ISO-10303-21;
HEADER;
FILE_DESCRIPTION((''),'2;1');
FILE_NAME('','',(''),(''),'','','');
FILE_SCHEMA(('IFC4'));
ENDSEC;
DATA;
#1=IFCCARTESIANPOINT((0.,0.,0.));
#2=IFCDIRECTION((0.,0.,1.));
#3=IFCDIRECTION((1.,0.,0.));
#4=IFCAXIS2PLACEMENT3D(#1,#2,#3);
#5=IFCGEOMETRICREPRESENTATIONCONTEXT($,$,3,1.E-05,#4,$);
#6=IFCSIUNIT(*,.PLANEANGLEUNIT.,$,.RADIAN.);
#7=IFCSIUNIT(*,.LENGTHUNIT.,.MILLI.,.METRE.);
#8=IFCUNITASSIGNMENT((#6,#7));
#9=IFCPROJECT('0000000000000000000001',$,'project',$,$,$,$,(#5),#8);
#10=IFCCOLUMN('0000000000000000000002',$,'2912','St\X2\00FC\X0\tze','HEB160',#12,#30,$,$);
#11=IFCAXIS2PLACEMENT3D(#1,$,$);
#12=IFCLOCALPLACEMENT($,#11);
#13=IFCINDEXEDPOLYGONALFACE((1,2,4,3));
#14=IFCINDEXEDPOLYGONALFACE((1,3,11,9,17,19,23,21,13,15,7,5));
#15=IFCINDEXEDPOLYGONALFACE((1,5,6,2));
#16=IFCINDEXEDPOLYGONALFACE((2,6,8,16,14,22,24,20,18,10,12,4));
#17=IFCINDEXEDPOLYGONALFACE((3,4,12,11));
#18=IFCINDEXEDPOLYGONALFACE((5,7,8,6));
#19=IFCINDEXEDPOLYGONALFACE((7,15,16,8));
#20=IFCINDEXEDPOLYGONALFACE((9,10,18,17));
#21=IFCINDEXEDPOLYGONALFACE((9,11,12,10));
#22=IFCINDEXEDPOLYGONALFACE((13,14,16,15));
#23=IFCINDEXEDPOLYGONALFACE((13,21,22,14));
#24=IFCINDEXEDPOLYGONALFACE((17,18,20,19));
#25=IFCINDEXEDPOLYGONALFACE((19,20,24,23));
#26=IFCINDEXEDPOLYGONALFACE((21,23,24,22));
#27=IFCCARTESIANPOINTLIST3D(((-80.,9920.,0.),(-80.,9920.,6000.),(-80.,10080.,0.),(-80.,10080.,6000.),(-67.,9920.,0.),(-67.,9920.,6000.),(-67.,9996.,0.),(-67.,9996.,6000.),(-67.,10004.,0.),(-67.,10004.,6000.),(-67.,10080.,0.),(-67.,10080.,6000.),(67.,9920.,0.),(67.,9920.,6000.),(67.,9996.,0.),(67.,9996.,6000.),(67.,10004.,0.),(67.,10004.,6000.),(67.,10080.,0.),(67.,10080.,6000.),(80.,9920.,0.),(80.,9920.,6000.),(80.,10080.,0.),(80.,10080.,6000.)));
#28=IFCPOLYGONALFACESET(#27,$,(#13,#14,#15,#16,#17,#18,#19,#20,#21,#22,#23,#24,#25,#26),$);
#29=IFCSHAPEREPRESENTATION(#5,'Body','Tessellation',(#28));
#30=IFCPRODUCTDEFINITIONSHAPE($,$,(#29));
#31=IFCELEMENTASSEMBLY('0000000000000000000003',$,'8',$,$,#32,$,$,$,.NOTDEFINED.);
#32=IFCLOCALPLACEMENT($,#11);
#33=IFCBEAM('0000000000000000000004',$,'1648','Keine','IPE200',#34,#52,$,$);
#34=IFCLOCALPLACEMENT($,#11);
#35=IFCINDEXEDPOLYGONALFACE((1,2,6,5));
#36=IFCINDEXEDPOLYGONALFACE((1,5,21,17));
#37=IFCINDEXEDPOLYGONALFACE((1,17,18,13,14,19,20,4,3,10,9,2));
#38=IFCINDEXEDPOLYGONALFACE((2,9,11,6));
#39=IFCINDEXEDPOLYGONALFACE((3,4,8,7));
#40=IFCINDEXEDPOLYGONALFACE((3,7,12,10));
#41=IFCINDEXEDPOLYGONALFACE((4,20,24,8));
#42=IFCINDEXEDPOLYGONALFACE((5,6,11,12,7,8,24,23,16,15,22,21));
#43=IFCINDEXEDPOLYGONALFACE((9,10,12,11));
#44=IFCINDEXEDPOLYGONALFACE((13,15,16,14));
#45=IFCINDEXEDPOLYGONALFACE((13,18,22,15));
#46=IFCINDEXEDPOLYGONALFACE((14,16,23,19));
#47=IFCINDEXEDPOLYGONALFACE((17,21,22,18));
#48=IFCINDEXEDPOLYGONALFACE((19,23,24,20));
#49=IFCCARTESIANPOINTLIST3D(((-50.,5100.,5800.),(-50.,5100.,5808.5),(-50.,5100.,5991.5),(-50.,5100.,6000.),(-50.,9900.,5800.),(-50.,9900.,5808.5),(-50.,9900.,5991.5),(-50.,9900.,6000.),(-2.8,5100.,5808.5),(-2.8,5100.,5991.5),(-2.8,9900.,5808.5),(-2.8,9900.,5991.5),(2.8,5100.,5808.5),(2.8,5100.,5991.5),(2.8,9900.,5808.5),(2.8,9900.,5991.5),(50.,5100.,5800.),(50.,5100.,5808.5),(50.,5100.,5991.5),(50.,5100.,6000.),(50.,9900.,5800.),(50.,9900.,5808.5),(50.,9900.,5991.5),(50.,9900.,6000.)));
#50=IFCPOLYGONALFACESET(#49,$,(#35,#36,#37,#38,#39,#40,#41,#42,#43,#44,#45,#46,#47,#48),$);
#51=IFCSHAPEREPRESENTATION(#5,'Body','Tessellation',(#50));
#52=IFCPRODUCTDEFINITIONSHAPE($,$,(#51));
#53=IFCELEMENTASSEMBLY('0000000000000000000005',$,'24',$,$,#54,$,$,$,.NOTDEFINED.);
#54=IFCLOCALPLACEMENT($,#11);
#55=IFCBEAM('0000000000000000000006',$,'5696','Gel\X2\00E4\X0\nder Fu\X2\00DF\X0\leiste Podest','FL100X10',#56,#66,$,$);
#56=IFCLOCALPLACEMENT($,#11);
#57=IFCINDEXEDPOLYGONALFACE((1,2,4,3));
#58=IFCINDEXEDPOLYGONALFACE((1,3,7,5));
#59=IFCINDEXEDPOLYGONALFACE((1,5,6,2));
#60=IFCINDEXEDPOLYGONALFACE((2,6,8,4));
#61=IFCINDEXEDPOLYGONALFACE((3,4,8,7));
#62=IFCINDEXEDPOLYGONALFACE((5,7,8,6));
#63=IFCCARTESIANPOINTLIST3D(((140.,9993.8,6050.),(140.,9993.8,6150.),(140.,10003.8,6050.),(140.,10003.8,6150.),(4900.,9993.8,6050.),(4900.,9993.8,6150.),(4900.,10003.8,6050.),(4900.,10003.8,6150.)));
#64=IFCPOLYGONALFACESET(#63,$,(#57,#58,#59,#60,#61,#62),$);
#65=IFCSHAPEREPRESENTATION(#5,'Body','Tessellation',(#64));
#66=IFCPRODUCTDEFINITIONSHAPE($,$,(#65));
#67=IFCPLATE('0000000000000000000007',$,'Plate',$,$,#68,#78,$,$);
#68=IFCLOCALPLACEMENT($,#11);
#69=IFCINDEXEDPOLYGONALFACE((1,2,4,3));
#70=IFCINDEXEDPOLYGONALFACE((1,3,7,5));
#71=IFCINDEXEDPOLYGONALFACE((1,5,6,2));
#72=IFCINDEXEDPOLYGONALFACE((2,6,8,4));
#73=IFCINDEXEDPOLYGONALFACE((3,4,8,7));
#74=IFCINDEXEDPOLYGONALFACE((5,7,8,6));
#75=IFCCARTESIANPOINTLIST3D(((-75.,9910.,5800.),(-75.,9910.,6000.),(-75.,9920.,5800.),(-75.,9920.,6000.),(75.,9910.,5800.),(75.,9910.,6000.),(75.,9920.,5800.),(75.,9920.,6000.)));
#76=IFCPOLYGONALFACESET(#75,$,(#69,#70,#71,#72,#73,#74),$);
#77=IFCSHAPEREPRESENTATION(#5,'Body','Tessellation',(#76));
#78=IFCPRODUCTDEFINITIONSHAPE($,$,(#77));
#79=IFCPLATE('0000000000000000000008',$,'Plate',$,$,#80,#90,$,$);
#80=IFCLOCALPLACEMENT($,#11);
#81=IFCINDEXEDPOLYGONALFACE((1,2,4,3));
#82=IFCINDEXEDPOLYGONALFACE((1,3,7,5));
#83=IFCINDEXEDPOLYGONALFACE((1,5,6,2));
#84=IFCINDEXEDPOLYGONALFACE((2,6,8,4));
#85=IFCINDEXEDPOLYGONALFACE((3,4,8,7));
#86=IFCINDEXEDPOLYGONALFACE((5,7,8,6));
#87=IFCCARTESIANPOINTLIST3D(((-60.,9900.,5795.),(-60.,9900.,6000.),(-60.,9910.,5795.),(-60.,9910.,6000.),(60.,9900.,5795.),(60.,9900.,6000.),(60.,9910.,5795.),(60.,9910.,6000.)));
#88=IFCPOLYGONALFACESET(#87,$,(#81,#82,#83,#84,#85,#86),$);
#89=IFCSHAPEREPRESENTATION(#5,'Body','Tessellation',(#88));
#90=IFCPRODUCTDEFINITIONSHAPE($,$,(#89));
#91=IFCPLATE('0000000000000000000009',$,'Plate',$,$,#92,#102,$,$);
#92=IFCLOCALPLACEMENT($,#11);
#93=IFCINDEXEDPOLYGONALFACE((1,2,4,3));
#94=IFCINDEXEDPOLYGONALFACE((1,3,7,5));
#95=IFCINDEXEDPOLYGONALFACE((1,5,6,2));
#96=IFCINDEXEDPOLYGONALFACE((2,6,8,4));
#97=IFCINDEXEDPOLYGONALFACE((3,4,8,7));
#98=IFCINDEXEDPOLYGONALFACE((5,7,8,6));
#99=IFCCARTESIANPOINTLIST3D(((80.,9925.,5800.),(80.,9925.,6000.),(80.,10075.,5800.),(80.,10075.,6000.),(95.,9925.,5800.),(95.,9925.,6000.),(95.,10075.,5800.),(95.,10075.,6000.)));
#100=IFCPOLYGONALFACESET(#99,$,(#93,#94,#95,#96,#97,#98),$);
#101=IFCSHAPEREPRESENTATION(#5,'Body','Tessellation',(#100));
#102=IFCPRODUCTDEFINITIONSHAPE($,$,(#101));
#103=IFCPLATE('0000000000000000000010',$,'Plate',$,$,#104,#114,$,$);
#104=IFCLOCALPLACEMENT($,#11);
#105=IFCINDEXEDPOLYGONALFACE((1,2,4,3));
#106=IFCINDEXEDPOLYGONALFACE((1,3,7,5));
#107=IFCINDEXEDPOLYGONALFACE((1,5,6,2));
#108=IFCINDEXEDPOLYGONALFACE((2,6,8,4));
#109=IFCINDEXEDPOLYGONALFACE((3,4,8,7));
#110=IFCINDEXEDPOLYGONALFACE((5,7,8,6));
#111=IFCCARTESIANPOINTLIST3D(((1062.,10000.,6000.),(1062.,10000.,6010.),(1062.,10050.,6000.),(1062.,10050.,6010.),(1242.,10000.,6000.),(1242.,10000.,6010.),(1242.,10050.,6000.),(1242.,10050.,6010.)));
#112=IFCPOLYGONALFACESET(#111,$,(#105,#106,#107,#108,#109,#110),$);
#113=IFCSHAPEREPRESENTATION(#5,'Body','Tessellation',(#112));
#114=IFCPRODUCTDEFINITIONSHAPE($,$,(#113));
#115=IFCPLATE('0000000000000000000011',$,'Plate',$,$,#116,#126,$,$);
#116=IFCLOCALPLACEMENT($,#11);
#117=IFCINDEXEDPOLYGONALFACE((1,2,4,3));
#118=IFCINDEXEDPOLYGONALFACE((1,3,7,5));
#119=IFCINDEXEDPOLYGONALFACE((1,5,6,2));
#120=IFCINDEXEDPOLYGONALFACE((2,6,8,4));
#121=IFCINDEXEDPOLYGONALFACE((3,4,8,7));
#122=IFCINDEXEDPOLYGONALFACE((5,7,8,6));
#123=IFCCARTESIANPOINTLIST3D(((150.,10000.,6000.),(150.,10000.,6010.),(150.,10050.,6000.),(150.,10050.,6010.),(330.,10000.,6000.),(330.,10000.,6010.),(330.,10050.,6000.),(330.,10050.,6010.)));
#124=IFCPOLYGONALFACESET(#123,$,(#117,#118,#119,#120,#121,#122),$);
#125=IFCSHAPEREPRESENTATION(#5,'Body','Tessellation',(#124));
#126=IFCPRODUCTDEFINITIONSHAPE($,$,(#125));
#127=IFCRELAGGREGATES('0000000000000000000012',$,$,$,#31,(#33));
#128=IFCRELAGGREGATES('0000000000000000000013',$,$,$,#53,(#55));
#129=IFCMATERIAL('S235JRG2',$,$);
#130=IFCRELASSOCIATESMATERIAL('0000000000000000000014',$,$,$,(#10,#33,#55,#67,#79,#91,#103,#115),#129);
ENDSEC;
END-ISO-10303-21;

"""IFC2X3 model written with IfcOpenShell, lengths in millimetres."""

from ifc_helpers import new_model, si_unit, frame, origin_with_axes, place, context, project, polyline, outline, extrude, clip, halfspace, material, element, aggregate, save


model = new_model("IFC2X3")

# Units and contexts
context_of_model = context(None, 3, precision=1e-05, world=origin_with_axes())
ifc_project = project(units=[si_unit("PLANEANGLEUNIT", "RADIAN"), si_unit("LENGTHUNIT", "METRE", prefix="MILLI")], contexts=[context_of_model])

# Column
ifc_material = material(Name="S235JRG2")
placement_1 = place(None, frame((0.0, 10000.0, 6000.0), z_axis=(-1.0, 0.0, 0.0), x_axis=(0.0, 0.0, -1.0)))
column_placement = place(placement_1, origin_with_axes())
element("IfcColumn", 1, at=column_placement, material=ifc_material, Name="2912", Description="Stütze", ObjectType="HEB160", context=context_of_model, shape_type="Clipping", body=[
    clip(extrude(outline(polyline([(80.0, -80.0), (80.0, -67.0), (4.0, -67.0), (4.0, 67.0), (80.0, 67.0), (80.0, 80.0), (-80.0, 80.0), (-80.0, 67.0), (-4.0, 67.0), (-4.0, -67.0), (-80.0, -67.0), (-80.0, -80.0), (80.0, -80.0), (80.0, -80.0)])), frame((0.0, 0.0, 0.0), z_axis=(1.0, 0.0, 0.0), x_axis=(0.0, 1.0, 0.0)), (0.0, 0.0, 1.0), 6000.0), halfspace(frame((6000.0, 0.0, 0.0), z_axis=(1.0, 0.0, 0.0), x_axis=(0.0, 0.0, 1.0)), False)),
])

# Element assembly, beam
assembly_1_placement = place(None, frame((0.0, 10000.0, 6000.0), z_axis=(0.0, 0.0, 1.0), x_axis=(0.0, -1.0, 0.0)))
assembly_1 = element("IfcElementAssembly", 2, at=assembly_1_placement, Name="8", PredefinedType="NOTDEFINED")
placement_2 = place(None, frame((0.0, 10000.0, 5900.0), z_axis=(0.0, 0.0, 1.0), x_axis=(0.0, -1.0, 0.0)))
beam_1_placement = place(placement_2, origin_with_axes())
beam_1 = element("IfcBeam", 3, at=beam_1_placement, material=ifc_material, Name="1648", Description="Keine", ObjectType="IPE200", context=context_of_model, shape_type="Clipping", body=[
    clip(clip(extrude(outline(polyline([(50.0, -100.0), (50.0, -91.5), (2.8, -91.5), (2.8, 91.5), (50.0, 91.5), (50.0, 100.0), (-50.0, 100.0), (-50.0, 91.5), (-2.8, 91.5), (-2.8, -91.5), (-50.0, -91.5), (-50.0, -100.0), (50.0, -100.0), (50.0, -100.0)])), frame((0.0, 0.0, 0.0), z_axis=(1.0, 0.0, 0.0), x_axis=(0.0, 1.0, 0.0)), (0.0, 0.0, 1.0), 5000.0), halfspace(frame((4900.0, 0.0, 100.0), z_axis=(1.0, 0.0, 0.0), x_axis=(0.0, 0.0, 1.0)), False)), halfspace(frame((100.0, 0.0, 100.0), z_axis=(-1.0, 0.0, 0.0), x_axis=(0.0, 0.0, -1.0)), False)),
])
aggregate(assembly_1, [beam_1])

# Element assembly, beam
assembly_2_placement = place(None, frame((140.0, 9998.8, 6100.0), z_axis=(0.0, 0.0, 1.0), x_axis=(1.0, 0.0, 0.0)))
assembly_2 = element("IfcElementAssembly", 4, at=assembly_2_placement, Name="24", PredefinedType="NOTDEFINED")
placement_3 = place(None, frame((140.0, 9998.8, 6100.0), z_axis=(0.0, 0.0, 1.0), x_axis=(1.0, 0.0, 0.0)))
beam_2_placement = place(placement_3, origin_with_axes())
beam_2 = element("IfcBeam", 5, at=beam_2_placement, material=ifc_material, Name="5696", Description="Geländer Fußleiste Podest", ObjectType="FL100X10", context=context_of_model, shape_type="SweptSolid", body=[
    extrude(outline(polyline([(5.0, -50.0), (5.0, 50.0), (-5.0, 50.0), (-5.0, -50.0), (5.0, -50.0), (5.0, -50.0)])), frame((0.0, 0.0, 0.0), z_axis=(1.0, 0.0, 0.0), x_axis=(0.0, 1.0, 0.0)), (0.0, 0.0, 1.0), 4760.0),
])
aggregate(assembly_2, [beam_2])

# Plates
placement_4 = place(None, origin_with_axes())
plate_1_placement = place(placement_4, frame((75.0, 9920.0, 6000.0), z_axis=(0.0, 0.0, -1.0), x_axis=(0.0, -1.0, 0.0)))
element("IfcPlate", 6, at=plate_1_placement, material=ifc_material, Name="Plate", context=context_of_model, shape_type="SweptSolid", body=[
    extrude(outline(polyline([(0.0, 0.0), (150.0, 0.0), (150.0, 200.0), (0.0, 200.0), (0.0, 0.0)])), frame((0.0, 0.0, 0.0), z_axis=(1.0, 0.0, 0.0), x_axis=(0.0, 1.0, 0.0)), (0.0, 0.0, 1.0), 10.0),
])
placement_5 = place(None, origin_with_axes())
plate_2_placement = place(placement_5, frame((60.0, 9900.0, 5795.0), z_axis=(0.0, 0.0, 1.0), x_axis=(0.0, 1.0, 0.0)))
element("IfcPlate", 7, at=plate_2_placement, material=ifc_material, Name="Plate", context=context_of_model, shape_type="SweptSolid", body=[
    extrude(outline(polyline([(0.0, 0.0), (120.0, 0.0), (120.0, 205.0), (0.0, 205.0), (0.0, 0.0)])), frame((0.0, 0.0, 0.0), z_axis=(1.0, 0.0, 0.0), x_axis=(0.0, 1.0, 0.0)), (0.0, 0.0, 1.0), 10.0),
])
placement_6 = place(None, origin_with_axes())
plate_3_placement = place(placement_6, frame((95.0, 9925.0, 5800.0), z_axis=(0.0, 1.0, 0.0), x_axis=(-1.0, 0.0, 0.0)))
element("IfcPlate", 8, at=plate_3_placement, material=ifc_material, Name="Plate", context=context_of_model, shape_type="SweptSolid", body=[
    extrude(outline(polyline([(0.0, 0.0), (200.0, 0.0), (200.0, 150.0), (0.0, 150.0), (0.0, 0.0)])), frame((0.0, 0.0, 0.0), z_axis=(1.0, 0.0, 0.0), x_axis=(0.0, 1.0, 0.0)), (0.0, 0.0, 1.0), 15.0),
])
placement_7 = place(None, origin_with_axes())
plate_4_placement = place(placement_7, frame((1242.0, 10000.0, 6010.0), z_axis=(0.0, 1.0, 0.0), x_axis=(0.0, 0.0, -1.0)))
element("IfcPlate", 9, at=plate_4_placement, material=ifc_material, Name="Plate", context=context_of_model, shape_type="SweptSolid", body=[
    extrude(outline(polyline([(0.0, 0.0), (180.0, 0.0), (180.0, 50.0), (0.0, 50.0), (0.0, 0.0)])), frame((0.0, 0.0, 0.0), z_axis=(1.0, 0.0, 0.0), x_axis=(0.0, 1.0, 0.0)), (0.0, 0.0, 1.0), 10.0),
])
placement_8 = place(None, origin_with_axes())
plate_5_placement = place(placement_8, frame((330.0, 10000.0, 6010.0), z_axis=(0.0, 1.0, 0.0), x_axis=(0.0, 0.0, -1.0)))
element("IfcPlate", 10, at=plate_5_placement, material=ifc_material, Name="Plate", context=context_of_model, shape_type="SweptSolid", body=[
    extrude(outline(polyline([(0.0, 0.0), (180.0, 0.0), (180.0, 50.0), (0.0, 50.0), (0.0, 0.0)])), frame((0.0, 0.0, 0.0), z_axis=(1.0, 0.0, 0.0), x_axis=(0.0, 1.0, 0.0)), (0.0, 0.0, 1.0), 10.0),
])

save(model, "model.ifc")
